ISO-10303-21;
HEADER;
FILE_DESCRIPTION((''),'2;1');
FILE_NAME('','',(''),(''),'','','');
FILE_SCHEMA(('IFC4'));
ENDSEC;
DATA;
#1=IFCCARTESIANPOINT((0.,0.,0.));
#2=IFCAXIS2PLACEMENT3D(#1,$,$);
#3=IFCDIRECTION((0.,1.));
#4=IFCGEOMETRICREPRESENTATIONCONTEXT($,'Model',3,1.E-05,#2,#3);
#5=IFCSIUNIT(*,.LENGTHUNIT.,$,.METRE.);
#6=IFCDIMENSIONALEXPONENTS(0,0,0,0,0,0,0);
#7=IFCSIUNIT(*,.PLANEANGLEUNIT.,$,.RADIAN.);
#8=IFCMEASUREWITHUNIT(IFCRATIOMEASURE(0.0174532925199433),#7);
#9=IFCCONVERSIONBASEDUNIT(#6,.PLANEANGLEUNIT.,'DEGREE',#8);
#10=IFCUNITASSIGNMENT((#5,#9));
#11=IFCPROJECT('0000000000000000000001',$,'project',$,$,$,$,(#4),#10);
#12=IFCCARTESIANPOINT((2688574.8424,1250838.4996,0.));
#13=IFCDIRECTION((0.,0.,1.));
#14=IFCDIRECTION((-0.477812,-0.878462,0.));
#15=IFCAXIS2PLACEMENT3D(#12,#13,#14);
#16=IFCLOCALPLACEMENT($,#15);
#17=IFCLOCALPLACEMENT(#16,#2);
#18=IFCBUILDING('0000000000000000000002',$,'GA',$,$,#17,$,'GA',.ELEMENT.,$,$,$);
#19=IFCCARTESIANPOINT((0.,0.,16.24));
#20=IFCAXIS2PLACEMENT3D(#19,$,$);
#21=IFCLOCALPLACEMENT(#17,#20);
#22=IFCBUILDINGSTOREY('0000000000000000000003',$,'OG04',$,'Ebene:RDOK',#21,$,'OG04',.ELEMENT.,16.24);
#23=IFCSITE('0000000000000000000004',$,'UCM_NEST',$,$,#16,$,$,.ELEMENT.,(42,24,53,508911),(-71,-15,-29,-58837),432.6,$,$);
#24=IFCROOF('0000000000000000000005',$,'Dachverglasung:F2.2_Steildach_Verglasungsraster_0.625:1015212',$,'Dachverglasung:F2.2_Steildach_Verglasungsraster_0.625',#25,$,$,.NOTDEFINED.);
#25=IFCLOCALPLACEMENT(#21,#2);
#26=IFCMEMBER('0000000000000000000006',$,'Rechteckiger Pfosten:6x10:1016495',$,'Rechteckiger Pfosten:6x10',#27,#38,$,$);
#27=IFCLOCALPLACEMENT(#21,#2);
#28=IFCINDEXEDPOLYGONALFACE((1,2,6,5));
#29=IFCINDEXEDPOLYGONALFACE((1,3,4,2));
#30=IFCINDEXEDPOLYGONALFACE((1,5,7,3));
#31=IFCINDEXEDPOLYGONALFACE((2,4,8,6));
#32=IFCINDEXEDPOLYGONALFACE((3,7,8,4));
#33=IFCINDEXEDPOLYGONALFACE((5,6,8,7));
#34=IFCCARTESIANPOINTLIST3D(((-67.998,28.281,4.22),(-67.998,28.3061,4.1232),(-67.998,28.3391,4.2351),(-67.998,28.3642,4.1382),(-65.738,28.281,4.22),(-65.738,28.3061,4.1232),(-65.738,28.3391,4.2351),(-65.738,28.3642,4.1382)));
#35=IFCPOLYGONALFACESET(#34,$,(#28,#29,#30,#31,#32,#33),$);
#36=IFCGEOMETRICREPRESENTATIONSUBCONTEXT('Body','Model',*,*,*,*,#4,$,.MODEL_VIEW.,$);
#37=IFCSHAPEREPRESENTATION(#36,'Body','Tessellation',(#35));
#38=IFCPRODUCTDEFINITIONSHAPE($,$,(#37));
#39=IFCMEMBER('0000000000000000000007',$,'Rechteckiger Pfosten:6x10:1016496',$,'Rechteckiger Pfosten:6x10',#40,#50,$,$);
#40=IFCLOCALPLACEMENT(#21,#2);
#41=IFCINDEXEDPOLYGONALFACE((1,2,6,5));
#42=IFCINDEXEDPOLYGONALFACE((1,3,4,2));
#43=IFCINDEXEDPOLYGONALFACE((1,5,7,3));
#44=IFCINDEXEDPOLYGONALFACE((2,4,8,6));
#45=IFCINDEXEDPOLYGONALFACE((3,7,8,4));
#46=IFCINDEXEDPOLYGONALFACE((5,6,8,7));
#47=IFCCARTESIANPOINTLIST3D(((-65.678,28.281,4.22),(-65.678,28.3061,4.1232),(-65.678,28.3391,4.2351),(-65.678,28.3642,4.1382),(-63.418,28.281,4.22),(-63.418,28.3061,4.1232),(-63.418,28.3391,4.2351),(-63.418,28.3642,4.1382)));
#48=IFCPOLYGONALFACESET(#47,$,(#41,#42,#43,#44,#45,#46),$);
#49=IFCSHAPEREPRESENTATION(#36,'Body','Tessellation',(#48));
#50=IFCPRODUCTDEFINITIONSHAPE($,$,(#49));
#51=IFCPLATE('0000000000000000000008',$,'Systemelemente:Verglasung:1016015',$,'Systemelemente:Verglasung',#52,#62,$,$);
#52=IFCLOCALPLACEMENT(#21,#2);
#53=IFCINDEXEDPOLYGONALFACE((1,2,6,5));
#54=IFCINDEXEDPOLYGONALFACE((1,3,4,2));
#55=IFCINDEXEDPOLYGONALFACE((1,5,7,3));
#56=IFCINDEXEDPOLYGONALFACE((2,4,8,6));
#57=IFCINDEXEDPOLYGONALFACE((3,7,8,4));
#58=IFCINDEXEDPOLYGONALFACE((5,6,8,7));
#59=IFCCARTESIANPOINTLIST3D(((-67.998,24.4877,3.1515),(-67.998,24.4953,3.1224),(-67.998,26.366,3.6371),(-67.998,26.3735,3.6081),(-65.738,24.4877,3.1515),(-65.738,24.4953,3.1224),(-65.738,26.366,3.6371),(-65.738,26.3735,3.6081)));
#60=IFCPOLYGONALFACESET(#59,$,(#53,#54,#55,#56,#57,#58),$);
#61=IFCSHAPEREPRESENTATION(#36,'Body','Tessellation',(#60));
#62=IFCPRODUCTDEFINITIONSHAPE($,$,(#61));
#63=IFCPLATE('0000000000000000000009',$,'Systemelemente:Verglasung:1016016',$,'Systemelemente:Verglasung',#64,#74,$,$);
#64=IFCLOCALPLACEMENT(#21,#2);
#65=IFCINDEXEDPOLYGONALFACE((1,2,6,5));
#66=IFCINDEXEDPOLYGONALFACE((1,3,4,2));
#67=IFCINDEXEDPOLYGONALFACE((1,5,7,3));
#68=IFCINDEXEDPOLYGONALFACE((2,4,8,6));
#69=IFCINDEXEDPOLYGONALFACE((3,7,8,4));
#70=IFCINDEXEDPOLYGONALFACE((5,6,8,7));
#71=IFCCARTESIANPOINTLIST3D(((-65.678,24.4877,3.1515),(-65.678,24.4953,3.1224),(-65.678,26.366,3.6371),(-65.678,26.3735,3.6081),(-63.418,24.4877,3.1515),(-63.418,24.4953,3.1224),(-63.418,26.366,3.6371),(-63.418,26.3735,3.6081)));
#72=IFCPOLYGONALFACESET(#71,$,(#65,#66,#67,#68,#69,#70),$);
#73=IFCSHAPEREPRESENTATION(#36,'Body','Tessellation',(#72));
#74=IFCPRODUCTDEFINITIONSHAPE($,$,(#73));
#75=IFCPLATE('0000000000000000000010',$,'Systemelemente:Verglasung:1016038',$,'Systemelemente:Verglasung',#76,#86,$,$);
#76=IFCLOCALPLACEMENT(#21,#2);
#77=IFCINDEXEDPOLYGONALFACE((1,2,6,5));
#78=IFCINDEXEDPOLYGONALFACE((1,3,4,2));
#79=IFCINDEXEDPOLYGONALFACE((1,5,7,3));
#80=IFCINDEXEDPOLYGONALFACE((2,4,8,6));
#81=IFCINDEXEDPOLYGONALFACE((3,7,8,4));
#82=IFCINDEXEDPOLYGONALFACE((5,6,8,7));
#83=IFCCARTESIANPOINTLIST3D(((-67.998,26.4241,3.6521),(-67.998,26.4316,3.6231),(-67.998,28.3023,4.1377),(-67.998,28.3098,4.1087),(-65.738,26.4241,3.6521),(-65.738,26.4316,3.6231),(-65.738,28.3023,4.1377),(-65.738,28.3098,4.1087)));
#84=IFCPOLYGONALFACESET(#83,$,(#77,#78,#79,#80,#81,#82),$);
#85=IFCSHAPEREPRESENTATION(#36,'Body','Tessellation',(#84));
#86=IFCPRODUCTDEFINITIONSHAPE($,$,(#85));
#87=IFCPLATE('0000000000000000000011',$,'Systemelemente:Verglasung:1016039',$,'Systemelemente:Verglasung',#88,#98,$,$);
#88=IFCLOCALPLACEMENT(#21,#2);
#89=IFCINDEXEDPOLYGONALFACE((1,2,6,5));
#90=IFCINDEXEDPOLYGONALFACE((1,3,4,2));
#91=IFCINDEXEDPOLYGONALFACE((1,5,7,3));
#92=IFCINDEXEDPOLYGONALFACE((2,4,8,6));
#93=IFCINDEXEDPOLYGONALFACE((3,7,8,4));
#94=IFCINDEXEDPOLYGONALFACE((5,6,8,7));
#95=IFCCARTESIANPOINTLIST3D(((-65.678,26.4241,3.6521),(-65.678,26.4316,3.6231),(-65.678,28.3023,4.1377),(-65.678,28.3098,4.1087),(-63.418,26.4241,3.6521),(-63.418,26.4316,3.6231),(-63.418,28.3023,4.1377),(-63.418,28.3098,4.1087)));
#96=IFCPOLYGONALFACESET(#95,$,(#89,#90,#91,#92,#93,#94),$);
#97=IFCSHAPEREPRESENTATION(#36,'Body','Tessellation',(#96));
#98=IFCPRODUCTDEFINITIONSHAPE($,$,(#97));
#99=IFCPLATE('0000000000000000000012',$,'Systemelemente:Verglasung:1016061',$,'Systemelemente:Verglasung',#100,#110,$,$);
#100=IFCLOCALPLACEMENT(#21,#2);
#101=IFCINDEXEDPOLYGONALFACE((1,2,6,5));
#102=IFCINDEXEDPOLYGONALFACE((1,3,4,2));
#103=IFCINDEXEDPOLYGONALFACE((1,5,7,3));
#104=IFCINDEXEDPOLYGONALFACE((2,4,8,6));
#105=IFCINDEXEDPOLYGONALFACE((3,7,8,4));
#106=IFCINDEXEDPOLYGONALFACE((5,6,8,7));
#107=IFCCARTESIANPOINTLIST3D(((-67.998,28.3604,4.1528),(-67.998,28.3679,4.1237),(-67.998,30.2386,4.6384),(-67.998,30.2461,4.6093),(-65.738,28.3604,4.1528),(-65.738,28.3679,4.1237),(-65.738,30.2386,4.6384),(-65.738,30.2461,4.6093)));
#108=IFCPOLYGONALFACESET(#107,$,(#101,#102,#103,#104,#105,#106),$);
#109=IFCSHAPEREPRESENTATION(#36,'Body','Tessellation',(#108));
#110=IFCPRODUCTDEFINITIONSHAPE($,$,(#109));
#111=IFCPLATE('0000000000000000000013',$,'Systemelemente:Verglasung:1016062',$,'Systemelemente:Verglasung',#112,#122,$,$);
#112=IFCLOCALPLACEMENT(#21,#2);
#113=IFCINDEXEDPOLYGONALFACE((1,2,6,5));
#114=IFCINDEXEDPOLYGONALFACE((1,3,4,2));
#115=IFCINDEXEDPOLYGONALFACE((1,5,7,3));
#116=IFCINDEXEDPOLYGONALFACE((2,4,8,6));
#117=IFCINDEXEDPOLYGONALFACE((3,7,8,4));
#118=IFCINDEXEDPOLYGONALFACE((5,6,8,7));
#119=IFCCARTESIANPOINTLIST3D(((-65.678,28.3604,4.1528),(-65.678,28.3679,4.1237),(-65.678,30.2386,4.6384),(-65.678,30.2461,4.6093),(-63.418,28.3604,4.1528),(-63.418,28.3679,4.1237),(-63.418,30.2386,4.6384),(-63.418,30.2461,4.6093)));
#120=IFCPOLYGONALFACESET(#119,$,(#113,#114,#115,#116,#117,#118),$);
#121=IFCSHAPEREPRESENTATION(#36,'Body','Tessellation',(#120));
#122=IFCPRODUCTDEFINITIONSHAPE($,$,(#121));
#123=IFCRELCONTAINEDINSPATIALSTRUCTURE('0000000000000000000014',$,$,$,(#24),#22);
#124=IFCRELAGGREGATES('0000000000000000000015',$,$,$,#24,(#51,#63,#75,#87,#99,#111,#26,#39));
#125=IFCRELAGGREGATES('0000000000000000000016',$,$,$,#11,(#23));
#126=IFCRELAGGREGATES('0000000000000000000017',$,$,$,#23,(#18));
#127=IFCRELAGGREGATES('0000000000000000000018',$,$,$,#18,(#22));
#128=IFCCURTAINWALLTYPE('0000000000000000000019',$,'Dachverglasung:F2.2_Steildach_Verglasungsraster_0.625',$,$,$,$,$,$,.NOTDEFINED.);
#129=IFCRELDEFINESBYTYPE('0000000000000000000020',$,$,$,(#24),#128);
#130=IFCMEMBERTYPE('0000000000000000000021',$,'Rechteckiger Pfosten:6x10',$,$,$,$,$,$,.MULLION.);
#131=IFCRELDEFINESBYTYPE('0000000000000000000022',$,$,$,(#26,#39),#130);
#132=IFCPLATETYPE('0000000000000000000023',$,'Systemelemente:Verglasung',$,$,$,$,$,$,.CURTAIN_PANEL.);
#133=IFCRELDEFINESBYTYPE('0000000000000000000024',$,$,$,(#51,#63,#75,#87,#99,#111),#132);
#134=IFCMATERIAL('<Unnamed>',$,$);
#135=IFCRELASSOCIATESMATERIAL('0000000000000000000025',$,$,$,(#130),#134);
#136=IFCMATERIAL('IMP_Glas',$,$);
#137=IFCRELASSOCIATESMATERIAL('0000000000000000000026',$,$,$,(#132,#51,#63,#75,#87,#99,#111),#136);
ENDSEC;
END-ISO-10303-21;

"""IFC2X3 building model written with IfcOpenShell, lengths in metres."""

from ifc_helpers import new_model, entity, si_unit, converted_unit, direction, frame, origin, origin_2d_with_axis, place, context, subcontext, project, spatial, rectangle, extrude, source, transform, mapped, material, type_object, type_shapes, element, aggregate, save


model = new_model("IFC2X3")

# Units and contexts
model_context = context("Model", 3, precision=1e-05, world=origin(), true_north=direction((0.0, 1.0)))
body_context = subcontext(model_context, "Body", "Model", "MODEL_VIEW")
ifc_project = project(units=[si_unit("LENGTHUNIT", "METRE"), converted_unit("PLANEANGLEUNIT", "DEGREE", entity("IfcRatioMeasure", 0.0174532925199433), si_unit("PLANEANGLEUNIT", "RADIAN"), dimensions=[0, 0, 0, 0, 0, 0, 0])], contexts=[model_context])

# Site, building, storey
site_placement = place(None, frame((2688574.8424, 1250838.4996, 0.0), z_axis=(0.0, 0.0, 1.0), x_axis=(-0.477812, -0.878462, 0.0)))
site = spatial("IfcSite", under=ifc_project, at=site_placement, Name="UCM_NEST", CompositionType="ELEMENT", RefLatitude=(42, 24, 53, 508911), RefLongitude=(-71, -15, -29, -58837), RefElevation=432.6)
building_placement = place(site_placement, origin())
building = spatial("IfcBuilding", under=site, at=building_placement, Name="GA", LongName="GA", CompositionType="ELEMENT")
storey_placement = place(building_placement, frame((0.0, 0.0, 16.24)))
storey = spatial("IfcBuildingStorey", under=building, at=storey_placement, Name="OG04", ObjectType="Ebene:RDOK", LongName="OG04", CompositionType="ELEMENT", Elevation=16.24)

# Roof, members, plates
curtain_wall_type = type_object("IfcCurtainWallType", Name="Dachverglasung:F2.2_Steildach_Verglasungsraster_0.625", PredefinedType="NOTDEFINED")
roof_placement = place(storey_placement, frame((0.0, 0.0, -16.24)))
roof = element("IfcRoof", 1, at=roof_placement, inside=storey, type_object=curtain_wall_type, Name="Dachverglasung:F2.2_Steildach_Verglasungsraster_0.625:1015212", ObjectType="Dachverglasung:F2.2_Steildach_Verglasungsraster_0.625", ShapeType="NOTDEFINED")
ifc_material_1 = material(Name="<Unnamed>")
member_type_1 = type_object("IfcMemberType", Name="Rechteckiger Pfosten:6x10", PredefinedType="MULLION", material=ifc_material_1)
shared_shape_1 = source(origin(), body_context, "Body", "SweptSolid", [
    extrude(rectangle(XDim=0.1, YDim=0.06, at=origin_2d_with_axis()), frame((-0.03, -0.05, -2.26), z_axis=(0.0, 0.0, 1.0), x_axis=(0.0, -1.0, 0.0)), (0.0, 0.0, 1.0), 2.26),
])
type_shapes(member_type_1, [shared_shape_1])
member_1_placement = place(roof_placement, frame((-67.998, 28.3642, 20.3782), z_axis=(-1.0, 0.0, 0.0), x_axis=(0.0, 0.968163, 0.250322)))
member_1 = element("IfcMember", 2, at=member_1_placement, type_object=member_type_1, Name="Rechteckiger Pfosten:6x10:1016495", ObjectType="Rechteckiger Pfosten:6x10", context=body_context, shape_type="MappedRepresentation", body=[
    mapped(shared_shape_1, transform((0.0, 0.0, 0.0), scale=1.0)),
])
member_2_placement = place(roof_placement, frame((-65.678, 28.3642, 20.3782), z_axis=(-1.0, 0.0, 0.0), x_axis=(0.0, 0.968163, 0.250322)))
member_2 = element("IfcMember", 3, at=member_2_placement, type_object=member_type_1, Name="Rechteckiger Pfosten:6x10:1016496", ObjectType="Rechteckiger Pfosten:6x10", context=body_context, shape_type="MappedRepresentation", body=[
    mapped(shared_shape_1, transform((0.0, 0.0, 0.0), scale=1.0)),
])
ifc_material_2 = material(Name="IMP_Glas")
plate_type = type_object("IfcPlateType", Name="Systemelemente:Verglasung", PredefinedType="CURTAIN_PANEL", material=ifc_material_2)
shared_shape_2 = source(origin(), body_context, "Body", "SweptSolid", [
    extrude(rectangle(XDim=0.03, YDim=2.26, at=origin_2d_with_axis()), frame((0.0, 0.0, 0.0), z_axis=(0.0, 0.0, 1.0), x_axis=(0.0, 1.0, 0.0)), (0.0, 0.0, 1.0), 1.94),
])
type_shapes(plate_type, [shared_shape_2])
plate_1_placement = place(roof_placement, frame((-66.868, 24.4915, 19.3769), z_axis=(0.0, 0.968163, 0.250322), x_axis=(1.0, 0.0, 0.0)))
plate_1 = element("IfcPlate", 4, at=plate_1_placement, type_object=plate_type, material=ifc_material_2, Name="Systemelemente:Verglasung:1016015", ObjectType="Systemelemente:Verglasung", context=body_context, shape_type="MappedRepresentation", body=[
    mapped(shared_shape_2, transform((0.0, 0.0, 0.0), scale=1.0)),
])
plate_2_placement = place(roof_placement, frame((-64.548, 24.4915, 19.3769), z_axis=(0.0, 0.968163, 0.250322), x_axis=(1.0, 0.0, 0.0)))
plate_2 = element("IfcPlate", 5, at=plate_2_placement, type_object=plate_type, material=ifc_material_2, Name="Systemelemente:Verglasung:1016016", ObjectType="Systemelemente:Verglasung", context=body_context, shape_type="MappedRepresentation", body=[
    mapped(shared_shape_2, transform((0.0, 0.0, 0.0), scale=1.0)),
])
plate_3_placement = place(roof_placement, frame((-66.868, 26.4278, 19.8776), z_axis=(0.0, 0.968163, 0.250322), x_axis=(1.0, 0.0, 0.0)))
plate_3 = element("IfcPlate", 6, at=plate_3_placement, type_object=plate_type, material=ifc_material_2, Name="Systemelemente:Verglasung:1016038", ObjectType="Systemelemente:Verglasung", context=body_context, shape_type="MappedRepresentation", body=[
    mapped(shared_shape_2, transform((0.0, 0.0, 0.0), scale=1.0)),
])
plate_4_placement = place(roof_placement, frame((-64.548, 26.4278, 19.8776), z_axis=(0.0, 0.968163, 0.250322), x_axis=(1.0, 0.0, 0.0)))
plate_4 = element("IfcPlate", 7, at=plate_4_placement, type_object=plate_type, material=ifc_material_2, Name="Systemelemente:Verglasung:1016039", ObjectType="Systemelemente:Verglasung", context=body_context, shape_type="MappedRepresentation", body=[
    mapped(shared_shape_2, transform((0.0, 0.0, 0.0), scale=1.0)),
])
plate_5_placement = place(roof_placement, frame((-66.868, 28.3642, 20.3782), z_axis=(0.0, 0.968163, 0.250322), x_axis=(1.0, 0.0, 0.0)))
plate_5 = element("IfcPlate", 8, at=plate_5_placement, type_object=plate_type, material=ifc_material_2, Name="Systemelemente:Verglasung:1016061", ObjectType="Systemelemente:Verglasung", context=body_context, shape_type="MappedRepresentation", body=[
    mapped(shared_shape_2, transform((0.0, 0.0, 0.0), scale=1.0)),
])
plate_6_placement = place(roof_placement, frame((-64.548, 28.3642, 20.3782), z_axis=(0.0, 0.968163, 0.250322), x_axis=(1.0, 0.0, 0.0)))
plate_6 = element("IfcPlate", 9, at=plate_6_placement, type_object=plate_type, material=ifc_material_2, Name="Systemelemente:Verglasung:1016062", ObjectType="Systemelemente:Verglasung", context=body_context, shape_type="MappedRepresentation", body=[
    mapped(shared_shape_2, transform((0.0, 0.0, 0.0), scale=1.0)),
])
aggregate(roof, [plate_1, plate_2, plate_3, plate_4, plate_5, plate_6, member_1, member_2])

save(model, "model.ifc")
